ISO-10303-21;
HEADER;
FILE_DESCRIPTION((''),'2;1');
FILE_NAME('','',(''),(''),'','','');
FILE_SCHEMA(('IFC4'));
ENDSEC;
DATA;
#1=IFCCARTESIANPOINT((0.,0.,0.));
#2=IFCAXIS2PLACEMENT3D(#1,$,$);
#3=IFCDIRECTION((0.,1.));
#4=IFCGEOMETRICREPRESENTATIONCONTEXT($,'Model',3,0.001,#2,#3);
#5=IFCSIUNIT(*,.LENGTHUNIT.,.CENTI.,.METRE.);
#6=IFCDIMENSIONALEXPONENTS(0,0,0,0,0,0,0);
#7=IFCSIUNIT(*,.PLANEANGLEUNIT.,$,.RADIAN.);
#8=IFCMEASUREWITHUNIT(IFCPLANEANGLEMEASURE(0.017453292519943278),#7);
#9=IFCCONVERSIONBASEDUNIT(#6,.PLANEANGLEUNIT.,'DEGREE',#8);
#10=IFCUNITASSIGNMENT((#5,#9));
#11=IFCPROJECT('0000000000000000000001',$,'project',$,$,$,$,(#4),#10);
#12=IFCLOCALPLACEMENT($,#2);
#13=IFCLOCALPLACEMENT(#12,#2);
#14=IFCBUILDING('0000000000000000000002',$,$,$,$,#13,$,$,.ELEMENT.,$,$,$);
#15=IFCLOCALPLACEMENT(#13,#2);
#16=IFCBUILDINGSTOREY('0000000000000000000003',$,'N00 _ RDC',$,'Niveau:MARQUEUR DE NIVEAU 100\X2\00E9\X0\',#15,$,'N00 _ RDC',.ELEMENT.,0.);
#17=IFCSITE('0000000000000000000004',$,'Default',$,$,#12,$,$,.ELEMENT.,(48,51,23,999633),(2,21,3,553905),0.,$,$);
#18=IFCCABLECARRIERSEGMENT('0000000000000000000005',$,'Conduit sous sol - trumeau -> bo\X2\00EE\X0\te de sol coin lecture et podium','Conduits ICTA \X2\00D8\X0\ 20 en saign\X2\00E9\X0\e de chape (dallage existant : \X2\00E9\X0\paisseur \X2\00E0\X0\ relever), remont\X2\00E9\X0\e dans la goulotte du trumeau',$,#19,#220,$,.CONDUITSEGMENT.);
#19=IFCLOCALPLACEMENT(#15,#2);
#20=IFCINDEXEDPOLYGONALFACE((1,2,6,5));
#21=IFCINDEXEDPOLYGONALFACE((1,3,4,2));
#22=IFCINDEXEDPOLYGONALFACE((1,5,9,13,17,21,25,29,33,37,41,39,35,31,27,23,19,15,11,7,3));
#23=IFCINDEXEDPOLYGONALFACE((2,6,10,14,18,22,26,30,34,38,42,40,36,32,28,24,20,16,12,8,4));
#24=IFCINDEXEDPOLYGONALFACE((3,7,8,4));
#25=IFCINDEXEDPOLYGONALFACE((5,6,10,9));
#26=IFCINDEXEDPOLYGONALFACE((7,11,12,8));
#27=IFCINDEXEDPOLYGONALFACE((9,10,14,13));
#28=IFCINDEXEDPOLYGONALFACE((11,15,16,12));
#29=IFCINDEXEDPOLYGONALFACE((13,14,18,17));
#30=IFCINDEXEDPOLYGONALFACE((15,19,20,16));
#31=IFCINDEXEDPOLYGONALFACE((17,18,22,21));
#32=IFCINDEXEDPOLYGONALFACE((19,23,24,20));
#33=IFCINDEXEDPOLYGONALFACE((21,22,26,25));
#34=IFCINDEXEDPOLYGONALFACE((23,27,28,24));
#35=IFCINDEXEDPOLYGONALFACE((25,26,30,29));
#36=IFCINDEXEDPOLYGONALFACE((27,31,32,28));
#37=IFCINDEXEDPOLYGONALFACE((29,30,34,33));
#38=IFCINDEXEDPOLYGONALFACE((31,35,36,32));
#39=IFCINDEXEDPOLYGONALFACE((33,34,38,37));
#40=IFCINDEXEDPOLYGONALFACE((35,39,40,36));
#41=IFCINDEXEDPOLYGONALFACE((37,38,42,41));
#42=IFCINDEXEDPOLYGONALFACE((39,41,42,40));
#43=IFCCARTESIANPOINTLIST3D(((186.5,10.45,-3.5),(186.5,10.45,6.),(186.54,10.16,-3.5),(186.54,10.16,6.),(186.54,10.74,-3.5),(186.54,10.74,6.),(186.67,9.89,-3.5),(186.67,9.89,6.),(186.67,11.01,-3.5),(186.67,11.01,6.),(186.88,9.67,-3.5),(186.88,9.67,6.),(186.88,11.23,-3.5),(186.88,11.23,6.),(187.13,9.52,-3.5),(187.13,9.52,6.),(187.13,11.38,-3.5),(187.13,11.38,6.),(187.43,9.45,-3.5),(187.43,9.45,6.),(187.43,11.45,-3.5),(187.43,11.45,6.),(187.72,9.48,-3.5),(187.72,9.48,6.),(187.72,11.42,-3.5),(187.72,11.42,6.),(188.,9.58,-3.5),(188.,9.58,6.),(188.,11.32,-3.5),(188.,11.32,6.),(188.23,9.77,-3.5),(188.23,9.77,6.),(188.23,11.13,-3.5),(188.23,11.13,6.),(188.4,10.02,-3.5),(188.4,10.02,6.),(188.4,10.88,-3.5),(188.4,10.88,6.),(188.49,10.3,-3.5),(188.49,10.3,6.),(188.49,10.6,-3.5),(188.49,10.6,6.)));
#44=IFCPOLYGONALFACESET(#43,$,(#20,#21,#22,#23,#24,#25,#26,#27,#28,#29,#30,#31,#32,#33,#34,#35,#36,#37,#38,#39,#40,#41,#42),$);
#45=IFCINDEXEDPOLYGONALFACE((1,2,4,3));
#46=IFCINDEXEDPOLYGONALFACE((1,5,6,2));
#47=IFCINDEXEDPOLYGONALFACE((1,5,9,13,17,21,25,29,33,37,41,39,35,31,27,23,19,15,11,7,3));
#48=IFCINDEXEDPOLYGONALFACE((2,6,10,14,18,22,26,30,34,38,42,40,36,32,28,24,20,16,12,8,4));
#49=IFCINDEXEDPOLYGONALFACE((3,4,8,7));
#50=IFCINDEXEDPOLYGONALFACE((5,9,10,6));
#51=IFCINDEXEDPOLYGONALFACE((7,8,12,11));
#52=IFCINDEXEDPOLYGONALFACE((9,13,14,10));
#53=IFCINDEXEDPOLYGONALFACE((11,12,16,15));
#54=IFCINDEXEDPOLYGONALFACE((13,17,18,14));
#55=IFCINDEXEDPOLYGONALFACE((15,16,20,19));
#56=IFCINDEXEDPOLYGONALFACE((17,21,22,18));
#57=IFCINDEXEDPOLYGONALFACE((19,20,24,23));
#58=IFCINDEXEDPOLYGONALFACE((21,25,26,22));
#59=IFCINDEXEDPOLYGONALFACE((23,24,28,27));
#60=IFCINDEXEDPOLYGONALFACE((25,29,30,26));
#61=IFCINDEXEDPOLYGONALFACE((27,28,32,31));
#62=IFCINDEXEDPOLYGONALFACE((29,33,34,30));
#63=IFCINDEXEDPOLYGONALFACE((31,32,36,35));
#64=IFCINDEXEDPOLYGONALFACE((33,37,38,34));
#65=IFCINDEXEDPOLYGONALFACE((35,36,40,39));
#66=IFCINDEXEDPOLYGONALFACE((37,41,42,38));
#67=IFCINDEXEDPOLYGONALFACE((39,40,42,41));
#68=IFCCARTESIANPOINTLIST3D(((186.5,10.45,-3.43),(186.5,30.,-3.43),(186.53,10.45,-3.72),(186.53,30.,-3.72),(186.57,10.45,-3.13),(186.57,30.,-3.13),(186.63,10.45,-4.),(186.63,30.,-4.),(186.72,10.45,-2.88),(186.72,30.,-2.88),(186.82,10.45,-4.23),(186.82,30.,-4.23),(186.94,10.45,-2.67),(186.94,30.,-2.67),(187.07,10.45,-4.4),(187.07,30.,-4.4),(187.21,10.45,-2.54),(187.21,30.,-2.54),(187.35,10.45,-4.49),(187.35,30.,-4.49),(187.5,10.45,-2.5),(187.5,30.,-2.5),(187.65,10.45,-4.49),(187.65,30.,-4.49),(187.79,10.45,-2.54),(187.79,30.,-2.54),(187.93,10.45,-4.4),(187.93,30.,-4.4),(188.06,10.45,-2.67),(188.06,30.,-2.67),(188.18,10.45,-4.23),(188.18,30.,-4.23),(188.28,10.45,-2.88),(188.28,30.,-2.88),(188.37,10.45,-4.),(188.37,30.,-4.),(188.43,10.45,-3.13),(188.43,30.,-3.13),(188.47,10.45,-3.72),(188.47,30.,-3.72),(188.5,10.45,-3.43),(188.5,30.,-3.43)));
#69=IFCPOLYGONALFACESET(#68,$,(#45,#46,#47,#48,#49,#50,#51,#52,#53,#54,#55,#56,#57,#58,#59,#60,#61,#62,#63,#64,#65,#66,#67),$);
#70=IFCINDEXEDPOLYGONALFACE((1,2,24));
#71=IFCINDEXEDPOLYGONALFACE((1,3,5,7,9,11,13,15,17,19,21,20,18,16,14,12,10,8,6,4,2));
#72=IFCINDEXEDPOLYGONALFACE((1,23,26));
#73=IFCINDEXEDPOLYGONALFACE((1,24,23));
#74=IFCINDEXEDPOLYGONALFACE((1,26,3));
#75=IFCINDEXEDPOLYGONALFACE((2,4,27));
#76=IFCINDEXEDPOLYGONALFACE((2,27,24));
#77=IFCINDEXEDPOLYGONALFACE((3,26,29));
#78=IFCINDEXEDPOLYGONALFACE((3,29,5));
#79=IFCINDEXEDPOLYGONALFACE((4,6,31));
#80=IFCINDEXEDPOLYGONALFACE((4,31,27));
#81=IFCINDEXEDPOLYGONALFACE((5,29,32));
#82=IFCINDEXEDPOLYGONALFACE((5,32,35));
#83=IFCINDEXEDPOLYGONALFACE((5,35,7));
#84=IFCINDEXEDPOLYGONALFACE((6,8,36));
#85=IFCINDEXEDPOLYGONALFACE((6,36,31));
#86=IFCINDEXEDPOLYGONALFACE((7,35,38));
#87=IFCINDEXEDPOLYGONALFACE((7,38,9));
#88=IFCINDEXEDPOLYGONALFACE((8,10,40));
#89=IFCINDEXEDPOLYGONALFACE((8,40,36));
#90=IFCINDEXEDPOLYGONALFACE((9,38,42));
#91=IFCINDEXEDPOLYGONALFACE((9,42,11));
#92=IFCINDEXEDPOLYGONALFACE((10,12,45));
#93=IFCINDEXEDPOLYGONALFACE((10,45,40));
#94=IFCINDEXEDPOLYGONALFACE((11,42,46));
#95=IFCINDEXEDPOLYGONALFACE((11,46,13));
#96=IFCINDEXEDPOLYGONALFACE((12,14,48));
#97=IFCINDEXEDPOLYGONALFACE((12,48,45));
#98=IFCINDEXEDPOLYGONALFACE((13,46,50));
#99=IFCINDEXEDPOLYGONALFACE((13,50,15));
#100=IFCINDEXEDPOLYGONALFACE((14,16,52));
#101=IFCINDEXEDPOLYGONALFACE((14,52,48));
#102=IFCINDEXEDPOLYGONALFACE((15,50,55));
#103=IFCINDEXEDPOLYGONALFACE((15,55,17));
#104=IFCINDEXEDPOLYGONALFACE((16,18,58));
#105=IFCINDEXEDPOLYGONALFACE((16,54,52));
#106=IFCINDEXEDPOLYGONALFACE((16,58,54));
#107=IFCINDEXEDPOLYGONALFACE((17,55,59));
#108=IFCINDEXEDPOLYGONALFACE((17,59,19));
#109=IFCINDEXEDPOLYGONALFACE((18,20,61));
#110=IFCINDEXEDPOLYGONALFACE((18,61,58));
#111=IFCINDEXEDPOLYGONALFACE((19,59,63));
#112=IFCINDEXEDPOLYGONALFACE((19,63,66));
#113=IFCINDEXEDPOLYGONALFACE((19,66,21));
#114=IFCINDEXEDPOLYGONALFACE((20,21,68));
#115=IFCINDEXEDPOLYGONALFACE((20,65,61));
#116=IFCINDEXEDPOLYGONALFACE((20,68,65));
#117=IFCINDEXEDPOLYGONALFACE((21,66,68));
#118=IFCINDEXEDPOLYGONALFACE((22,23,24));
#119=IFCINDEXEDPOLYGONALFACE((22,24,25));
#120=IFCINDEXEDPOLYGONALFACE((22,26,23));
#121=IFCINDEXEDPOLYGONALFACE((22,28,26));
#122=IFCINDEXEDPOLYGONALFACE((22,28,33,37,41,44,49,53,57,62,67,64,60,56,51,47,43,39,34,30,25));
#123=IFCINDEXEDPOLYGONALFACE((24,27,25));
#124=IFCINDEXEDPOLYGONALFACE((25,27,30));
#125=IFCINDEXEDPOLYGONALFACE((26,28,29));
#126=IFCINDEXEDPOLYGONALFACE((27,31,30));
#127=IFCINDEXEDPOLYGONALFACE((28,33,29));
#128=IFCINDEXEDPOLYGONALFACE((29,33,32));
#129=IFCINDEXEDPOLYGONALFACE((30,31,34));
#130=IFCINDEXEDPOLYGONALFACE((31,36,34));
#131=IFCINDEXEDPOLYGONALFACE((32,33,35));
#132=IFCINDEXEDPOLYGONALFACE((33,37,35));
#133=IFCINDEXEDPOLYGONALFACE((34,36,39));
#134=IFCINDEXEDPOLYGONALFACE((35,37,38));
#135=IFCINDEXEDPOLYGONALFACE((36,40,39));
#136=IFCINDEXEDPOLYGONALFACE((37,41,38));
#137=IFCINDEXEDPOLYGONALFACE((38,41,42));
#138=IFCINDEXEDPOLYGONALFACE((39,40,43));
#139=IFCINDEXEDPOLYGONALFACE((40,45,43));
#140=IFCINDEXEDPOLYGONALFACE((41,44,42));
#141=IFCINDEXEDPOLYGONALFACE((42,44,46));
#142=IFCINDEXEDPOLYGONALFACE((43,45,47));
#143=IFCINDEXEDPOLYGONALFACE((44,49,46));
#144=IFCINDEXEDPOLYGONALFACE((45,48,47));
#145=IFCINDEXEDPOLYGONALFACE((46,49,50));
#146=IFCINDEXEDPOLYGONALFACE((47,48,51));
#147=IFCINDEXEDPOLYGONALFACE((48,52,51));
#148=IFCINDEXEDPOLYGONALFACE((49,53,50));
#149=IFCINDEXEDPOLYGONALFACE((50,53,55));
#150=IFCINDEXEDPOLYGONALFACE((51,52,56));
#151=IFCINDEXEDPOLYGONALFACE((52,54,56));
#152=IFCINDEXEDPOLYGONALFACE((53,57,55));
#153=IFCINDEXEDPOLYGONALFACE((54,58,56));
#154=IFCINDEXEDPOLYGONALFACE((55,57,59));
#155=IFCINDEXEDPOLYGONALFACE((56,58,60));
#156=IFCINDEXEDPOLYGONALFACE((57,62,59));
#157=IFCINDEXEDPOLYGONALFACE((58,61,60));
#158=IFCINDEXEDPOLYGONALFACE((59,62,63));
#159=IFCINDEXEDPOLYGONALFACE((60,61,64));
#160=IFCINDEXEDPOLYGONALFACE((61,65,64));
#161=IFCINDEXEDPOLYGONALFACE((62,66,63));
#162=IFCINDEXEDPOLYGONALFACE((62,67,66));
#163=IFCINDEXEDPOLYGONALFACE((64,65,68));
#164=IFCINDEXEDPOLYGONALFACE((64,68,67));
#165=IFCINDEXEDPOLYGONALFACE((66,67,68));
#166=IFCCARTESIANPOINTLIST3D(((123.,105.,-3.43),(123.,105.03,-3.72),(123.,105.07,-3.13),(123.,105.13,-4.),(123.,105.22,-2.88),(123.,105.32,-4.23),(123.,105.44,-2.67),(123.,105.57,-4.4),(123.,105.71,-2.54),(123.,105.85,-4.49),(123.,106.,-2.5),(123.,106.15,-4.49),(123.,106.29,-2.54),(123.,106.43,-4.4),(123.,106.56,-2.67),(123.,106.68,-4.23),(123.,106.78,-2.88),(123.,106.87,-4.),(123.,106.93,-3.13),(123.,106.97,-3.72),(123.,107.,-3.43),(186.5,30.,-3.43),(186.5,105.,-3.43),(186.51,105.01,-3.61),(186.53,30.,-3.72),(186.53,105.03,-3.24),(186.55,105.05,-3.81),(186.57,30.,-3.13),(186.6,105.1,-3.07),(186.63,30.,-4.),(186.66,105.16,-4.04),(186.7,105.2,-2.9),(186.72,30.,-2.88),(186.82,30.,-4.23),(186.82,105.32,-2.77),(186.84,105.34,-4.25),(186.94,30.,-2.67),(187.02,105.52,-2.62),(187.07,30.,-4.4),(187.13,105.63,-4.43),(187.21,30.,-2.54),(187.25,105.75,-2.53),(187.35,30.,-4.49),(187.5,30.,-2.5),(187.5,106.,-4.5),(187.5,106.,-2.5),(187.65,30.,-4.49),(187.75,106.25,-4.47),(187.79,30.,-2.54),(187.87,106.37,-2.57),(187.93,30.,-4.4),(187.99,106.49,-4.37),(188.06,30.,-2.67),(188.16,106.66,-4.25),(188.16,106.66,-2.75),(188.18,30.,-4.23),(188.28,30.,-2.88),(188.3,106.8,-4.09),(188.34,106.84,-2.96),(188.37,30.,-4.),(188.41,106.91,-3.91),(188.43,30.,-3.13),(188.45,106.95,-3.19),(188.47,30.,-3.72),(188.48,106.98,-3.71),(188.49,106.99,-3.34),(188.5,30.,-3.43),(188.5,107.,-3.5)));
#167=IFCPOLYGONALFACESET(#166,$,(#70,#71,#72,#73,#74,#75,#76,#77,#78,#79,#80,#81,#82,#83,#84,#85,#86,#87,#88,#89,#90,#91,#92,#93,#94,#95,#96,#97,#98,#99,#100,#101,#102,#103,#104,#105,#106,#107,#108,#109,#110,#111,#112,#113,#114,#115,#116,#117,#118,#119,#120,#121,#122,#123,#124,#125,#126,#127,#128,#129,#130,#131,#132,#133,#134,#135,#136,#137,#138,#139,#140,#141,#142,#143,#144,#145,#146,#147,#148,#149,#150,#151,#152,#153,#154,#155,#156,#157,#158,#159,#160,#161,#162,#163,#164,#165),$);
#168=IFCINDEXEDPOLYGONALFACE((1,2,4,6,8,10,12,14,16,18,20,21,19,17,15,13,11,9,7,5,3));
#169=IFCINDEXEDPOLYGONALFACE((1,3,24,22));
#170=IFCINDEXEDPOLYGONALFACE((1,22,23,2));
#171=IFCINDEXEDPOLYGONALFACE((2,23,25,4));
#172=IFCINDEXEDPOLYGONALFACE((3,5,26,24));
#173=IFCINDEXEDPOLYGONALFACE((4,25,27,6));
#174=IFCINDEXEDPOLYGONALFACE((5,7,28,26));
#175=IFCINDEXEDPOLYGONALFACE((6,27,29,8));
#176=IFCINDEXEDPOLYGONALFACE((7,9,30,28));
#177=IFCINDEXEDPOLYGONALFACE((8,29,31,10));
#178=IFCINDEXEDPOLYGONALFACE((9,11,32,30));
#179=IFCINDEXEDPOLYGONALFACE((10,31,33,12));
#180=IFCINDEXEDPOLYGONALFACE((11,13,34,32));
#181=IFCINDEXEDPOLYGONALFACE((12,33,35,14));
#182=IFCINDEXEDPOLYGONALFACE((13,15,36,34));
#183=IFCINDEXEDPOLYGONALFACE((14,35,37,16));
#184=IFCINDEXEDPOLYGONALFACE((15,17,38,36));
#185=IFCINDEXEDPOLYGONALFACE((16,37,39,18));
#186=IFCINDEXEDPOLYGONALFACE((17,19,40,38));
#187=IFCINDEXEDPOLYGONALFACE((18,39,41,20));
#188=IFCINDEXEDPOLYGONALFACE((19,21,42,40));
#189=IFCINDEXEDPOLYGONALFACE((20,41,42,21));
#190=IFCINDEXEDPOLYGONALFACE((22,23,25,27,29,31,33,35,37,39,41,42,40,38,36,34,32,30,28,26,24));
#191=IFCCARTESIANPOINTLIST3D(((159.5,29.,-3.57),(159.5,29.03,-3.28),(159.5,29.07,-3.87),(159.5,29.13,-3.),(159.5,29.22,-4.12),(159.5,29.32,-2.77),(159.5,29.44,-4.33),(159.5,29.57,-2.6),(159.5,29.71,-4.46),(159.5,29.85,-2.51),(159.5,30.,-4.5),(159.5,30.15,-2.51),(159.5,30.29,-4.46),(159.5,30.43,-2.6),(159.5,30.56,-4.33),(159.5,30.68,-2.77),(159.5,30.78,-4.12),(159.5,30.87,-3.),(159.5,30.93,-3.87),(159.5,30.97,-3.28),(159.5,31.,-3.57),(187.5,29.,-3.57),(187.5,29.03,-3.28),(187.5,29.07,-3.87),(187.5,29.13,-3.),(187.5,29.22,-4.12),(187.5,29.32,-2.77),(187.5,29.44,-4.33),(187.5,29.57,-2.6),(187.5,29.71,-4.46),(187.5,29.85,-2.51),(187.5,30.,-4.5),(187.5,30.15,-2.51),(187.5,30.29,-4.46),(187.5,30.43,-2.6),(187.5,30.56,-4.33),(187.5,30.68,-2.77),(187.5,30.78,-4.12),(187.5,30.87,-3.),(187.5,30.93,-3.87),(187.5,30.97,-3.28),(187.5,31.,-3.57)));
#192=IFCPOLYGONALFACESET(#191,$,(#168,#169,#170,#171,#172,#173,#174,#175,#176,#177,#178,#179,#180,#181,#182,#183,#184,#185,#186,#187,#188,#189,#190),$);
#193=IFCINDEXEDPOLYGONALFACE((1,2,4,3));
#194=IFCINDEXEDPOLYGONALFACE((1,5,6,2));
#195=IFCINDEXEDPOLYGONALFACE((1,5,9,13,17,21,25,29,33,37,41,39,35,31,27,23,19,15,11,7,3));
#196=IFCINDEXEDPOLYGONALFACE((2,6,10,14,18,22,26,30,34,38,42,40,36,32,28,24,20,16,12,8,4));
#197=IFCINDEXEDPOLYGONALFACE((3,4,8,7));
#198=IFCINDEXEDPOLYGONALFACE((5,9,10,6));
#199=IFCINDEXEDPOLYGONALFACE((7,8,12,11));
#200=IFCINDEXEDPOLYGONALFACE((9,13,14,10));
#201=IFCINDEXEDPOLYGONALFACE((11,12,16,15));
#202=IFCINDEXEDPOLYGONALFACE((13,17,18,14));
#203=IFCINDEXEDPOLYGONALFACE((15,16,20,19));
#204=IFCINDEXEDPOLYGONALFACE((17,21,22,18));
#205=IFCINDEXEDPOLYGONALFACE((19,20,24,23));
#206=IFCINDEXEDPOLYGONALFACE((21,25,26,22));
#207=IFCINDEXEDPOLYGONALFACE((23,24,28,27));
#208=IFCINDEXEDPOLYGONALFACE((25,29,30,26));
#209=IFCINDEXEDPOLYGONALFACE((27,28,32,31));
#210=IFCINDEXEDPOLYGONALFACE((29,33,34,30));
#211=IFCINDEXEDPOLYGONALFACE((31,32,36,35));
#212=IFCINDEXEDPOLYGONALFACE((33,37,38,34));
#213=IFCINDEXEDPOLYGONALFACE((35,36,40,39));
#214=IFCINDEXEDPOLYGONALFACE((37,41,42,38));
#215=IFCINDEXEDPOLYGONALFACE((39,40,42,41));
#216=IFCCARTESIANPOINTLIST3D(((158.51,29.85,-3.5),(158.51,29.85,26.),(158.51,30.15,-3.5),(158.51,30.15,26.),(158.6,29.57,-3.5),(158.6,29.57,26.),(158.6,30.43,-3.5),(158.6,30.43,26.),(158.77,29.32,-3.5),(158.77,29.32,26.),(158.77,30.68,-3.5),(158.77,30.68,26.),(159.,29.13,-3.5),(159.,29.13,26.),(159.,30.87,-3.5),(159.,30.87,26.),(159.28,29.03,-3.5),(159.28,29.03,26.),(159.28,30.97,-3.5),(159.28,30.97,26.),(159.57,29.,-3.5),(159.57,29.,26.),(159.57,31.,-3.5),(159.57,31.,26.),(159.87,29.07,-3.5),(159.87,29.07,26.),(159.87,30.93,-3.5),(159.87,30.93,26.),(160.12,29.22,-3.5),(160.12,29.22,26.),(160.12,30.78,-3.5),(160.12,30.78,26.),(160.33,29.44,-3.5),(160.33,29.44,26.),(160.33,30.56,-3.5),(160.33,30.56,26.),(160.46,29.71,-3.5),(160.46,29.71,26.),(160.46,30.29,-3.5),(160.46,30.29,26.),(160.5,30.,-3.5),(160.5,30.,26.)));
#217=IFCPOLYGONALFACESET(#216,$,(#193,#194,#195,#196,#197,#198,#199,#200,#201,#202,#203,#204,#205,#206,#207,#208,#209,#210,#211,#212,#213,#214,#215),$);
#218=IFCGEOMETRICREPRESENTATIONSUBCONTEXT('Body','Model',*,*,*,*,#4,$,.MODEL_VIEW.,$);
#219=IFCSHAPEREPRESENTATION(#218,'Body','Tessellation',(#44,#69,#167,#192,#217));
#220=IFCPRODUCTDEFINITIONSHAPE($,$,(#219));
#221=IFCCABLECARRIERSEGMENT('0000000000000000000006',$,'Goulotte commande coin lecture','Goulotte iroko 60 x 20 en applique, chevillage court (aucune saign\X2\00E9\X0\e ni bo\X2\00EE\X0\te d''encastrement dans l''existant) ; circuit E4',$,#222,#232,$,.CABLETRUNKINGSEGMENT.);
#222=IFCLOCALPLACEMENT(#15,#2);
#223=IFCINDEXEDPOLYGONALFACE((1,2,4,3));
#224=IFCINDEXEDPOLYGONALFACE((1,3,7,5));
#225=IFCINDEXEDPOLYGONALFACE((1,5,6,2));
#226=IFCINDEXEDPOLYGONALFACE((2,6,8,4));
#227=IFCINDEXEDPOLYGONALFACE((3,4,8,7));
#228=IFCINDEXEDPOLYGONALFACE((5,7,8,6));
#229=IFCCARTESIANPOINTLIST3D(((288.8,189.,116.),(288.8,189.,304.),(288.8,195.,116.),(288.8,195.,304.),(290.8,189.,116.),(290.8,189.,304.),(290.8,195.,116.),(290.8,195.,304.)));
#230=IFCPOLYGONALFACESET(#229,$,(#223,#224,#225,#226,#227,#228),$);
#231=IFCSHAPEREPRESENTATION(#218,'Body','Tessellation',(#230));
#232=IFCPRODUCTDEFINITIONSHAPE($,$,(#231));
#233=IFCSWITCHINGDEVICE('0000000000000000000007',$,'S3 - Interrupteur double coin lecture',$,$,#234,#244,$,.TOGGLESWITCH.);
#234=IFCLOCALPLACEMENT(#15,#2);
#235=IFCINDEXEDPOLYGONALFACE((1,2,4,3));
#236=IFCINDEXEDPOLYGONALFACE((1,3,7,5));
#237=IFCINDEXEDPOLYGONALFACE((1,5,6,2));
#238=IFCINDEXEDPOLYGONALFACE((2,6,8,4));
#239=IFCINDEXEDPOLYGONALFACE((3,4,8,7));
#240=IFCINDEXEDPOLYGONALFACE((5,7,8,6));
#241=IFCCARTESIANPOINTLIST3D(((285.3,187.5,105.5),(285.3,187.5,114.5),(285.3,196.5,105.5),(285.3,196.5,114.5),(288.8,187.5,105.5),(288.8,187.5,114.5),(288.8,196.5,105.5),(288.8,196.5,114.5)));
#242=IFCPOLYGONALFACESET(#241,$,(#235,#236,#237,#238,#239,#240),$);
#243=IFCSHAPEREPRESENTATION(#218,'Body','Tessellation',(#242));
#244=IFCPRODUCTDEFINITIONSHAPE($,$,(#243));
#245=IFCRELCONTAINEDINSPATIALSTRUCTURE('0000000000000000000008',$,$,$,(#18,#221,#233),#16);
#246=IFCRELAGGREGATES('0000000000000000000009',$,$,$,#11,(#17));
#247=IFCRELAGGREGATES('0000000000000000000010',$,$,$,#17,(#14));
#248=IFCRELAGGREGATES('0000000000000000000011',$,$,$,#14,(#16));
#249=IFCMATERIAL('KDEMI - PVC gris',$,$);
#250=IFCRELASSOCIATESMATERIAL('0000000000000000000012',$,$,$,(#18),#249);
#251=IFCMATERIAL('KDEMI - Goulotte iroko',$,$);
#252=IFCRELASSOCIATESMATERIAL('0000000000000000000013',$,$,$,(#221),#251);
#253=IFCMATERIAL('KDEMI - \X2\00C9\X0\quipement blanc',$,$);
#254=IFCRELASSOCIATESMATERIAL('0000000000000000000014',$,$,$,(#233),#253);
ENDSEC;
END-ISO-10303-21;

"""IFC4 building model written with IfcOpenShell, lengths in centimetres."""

from ifc_helpers import new_model, entity, si_unit, converted_unit, direction, frame, frame_2d, origin, origin_with_axes, place, context, subcontext, project, spatial, rectangle, extrude, material, element, save


model = new_model("IFC4")

# Units and contexts
model_context = context("Model", 3, precision=0.001, world=origin(), true_north=direction((0.0, 1.0)))
body_context = subcontext(model_context, "Body", "Model", "MODEL_VIEW")
ifc_project = project(units=[si_unit("LENGTHUNIT", "METRE", prefix="CENTI"), converted_unit("PLANEANGLEUNIT", "DEGREE", entity("IfcPlaneAngleMeasure", 0.017453292519943278), si_unit("PLANEANGLEUNIT", "RADIAN"), dimensions=[0, 0, 0, 0, 0, 0, 0])], contexts=[model_context])

# Site, building, storey
site_placement = place(None, origin())
site = spatial("IfcSite", under=ifc_project, at=site_placement, Name="Default", CompositionType="ELEMENT", RefLatitude=(48, 51, 23, 999633), RefLongitude=(2, 21, 3, 553905), RefElevation=0.0)
building_placement = place(site_placement, origin())
building = spatial("IfcBuilding", under=site, at=building_placement, CompositionType="ELEMENT")
storey_placement = place(building_placement, origin())
storey = spatial("IfcBuildingStorey", under=building, at=storey_placement, Name="N00 _ RDC", ObjectType="Niveau:MARQUEUR DE NIVEAU 100é", LongName="N00 _ RDC", CompositionType="ELEMENT", Elevation=0.0)

# Cable carrier segments
ifc_material_1 = material(Name="KDEMI - PVC gris")
cable_carrier_segment_1_placement = place(storey_placement, origin_with_axes())
element("IfcCableCarrierSegment", 1, at=cable_carrier_segment_1_placement, inside=storey, material=ifc_material_1, Name="Conduit sous sol - trumeau -> boîte de sol coin lecture et podium", Description="Conduits ICTA Ø 20 en saignée de chape (dallage existant : épaisseur à relever), remontée dans la goulotte du trumeau", PredefinedType="CONDUITSEGMENT", context=body_context, shape_type="AdvancedSweptSolid", body=[
    entity("IfcSweptDiskSolid", entity("IfcPolyline", [entity("IfcCartesianPoint", [187.5, 10.45, 6.0]), entity("IfcCartesianPoint", [187.5, 10.45, -3.5])]), 1.0),
    entity("IfcSweptDiskSolid", entity("IfcPolyline", [entity("IfcCartesianPoint", [187.5, 10.45, -3.5]), entity("IfcCartesianPoint", [187.5, 30.0, -3.5])]), 1.0),
    entity("IfcSweptDiskSolid", entity("IfcPolyline", [entity("IfcCartesianPoint", [187.5, 30.0, -3.5]), entity("IfcCartesianPoint", [187.5, 106.0, -3.5]), entity("IfcCartesianPoint", [123.0, 106.0, -3.5])]), 1.0),
    entity("IfcSweptDiskSolid", entity("IfcPolyline", [entity("IfcCartesianPoint", [187.5, 30.0, -3.5]), entity("IfcCartesianPoint", [159.5, 30.0, -3.5])]), 1.0),
    entity("IfcSweptDiskSolid", entity("IfcPolyline", [entity("IfcCartesianPoint", [159.5, 30.0, -3.5]), entity("IfcCartesianPoint", [159.5, 30.0, 26.0])]), 1.0),
])
ifc_material_2 = material(Name="KDEMI - Goulotte iroko")
cable_carrier_segment_2_placement = place(storey_placement, origin_with_axes())
element("IfcCableCarrierSegment", 2, at=cable_carrier_segment_2_placement, inside=storey, material=ifc_material_2, Name="Goulotte commande coin lecture", Description="Goulotte iroko 60 x 20 en applique, chevillage court (aucune saignée ni boîte d'encastrement dans l'existant) ; circuit E4", PredefinedType="CABLETRUNKINGSEGMENT", context=body_context, shape_type="SweptSolid", body=[
    extrude(rectangle(XDim=2.0, YDim=6.0, at=frame_2d((289.8, 192.0))), frame((0.0, 0.0, 116.0)), (0.0, 0.0, 1.0), 188.0),
])

# Switching device
ifc_material_3 = material(Name="KDEMI - Équipement blanc")
switching_device_1_placement = place(storey_placement, origin_with_axes())
element("IfcSwitchingDevice", 3, at=switching_device_1_placement, inside=storey, material=ifc_material_3, Name="S3 - Interrupteur double coin lecture", PredefinedType="TOGGLESWITCH", context=body_context, shape_type="SweptSolid", body=[
    extrude(rectangle(XDim=3.5, YDim=9.0, at=frame_2d((287.05, 192.0))), frame((0.0, 0.0, 105.5)), (0.0, 0.0, 1.0), 9.0),
])

save(model, "model.ifc")
